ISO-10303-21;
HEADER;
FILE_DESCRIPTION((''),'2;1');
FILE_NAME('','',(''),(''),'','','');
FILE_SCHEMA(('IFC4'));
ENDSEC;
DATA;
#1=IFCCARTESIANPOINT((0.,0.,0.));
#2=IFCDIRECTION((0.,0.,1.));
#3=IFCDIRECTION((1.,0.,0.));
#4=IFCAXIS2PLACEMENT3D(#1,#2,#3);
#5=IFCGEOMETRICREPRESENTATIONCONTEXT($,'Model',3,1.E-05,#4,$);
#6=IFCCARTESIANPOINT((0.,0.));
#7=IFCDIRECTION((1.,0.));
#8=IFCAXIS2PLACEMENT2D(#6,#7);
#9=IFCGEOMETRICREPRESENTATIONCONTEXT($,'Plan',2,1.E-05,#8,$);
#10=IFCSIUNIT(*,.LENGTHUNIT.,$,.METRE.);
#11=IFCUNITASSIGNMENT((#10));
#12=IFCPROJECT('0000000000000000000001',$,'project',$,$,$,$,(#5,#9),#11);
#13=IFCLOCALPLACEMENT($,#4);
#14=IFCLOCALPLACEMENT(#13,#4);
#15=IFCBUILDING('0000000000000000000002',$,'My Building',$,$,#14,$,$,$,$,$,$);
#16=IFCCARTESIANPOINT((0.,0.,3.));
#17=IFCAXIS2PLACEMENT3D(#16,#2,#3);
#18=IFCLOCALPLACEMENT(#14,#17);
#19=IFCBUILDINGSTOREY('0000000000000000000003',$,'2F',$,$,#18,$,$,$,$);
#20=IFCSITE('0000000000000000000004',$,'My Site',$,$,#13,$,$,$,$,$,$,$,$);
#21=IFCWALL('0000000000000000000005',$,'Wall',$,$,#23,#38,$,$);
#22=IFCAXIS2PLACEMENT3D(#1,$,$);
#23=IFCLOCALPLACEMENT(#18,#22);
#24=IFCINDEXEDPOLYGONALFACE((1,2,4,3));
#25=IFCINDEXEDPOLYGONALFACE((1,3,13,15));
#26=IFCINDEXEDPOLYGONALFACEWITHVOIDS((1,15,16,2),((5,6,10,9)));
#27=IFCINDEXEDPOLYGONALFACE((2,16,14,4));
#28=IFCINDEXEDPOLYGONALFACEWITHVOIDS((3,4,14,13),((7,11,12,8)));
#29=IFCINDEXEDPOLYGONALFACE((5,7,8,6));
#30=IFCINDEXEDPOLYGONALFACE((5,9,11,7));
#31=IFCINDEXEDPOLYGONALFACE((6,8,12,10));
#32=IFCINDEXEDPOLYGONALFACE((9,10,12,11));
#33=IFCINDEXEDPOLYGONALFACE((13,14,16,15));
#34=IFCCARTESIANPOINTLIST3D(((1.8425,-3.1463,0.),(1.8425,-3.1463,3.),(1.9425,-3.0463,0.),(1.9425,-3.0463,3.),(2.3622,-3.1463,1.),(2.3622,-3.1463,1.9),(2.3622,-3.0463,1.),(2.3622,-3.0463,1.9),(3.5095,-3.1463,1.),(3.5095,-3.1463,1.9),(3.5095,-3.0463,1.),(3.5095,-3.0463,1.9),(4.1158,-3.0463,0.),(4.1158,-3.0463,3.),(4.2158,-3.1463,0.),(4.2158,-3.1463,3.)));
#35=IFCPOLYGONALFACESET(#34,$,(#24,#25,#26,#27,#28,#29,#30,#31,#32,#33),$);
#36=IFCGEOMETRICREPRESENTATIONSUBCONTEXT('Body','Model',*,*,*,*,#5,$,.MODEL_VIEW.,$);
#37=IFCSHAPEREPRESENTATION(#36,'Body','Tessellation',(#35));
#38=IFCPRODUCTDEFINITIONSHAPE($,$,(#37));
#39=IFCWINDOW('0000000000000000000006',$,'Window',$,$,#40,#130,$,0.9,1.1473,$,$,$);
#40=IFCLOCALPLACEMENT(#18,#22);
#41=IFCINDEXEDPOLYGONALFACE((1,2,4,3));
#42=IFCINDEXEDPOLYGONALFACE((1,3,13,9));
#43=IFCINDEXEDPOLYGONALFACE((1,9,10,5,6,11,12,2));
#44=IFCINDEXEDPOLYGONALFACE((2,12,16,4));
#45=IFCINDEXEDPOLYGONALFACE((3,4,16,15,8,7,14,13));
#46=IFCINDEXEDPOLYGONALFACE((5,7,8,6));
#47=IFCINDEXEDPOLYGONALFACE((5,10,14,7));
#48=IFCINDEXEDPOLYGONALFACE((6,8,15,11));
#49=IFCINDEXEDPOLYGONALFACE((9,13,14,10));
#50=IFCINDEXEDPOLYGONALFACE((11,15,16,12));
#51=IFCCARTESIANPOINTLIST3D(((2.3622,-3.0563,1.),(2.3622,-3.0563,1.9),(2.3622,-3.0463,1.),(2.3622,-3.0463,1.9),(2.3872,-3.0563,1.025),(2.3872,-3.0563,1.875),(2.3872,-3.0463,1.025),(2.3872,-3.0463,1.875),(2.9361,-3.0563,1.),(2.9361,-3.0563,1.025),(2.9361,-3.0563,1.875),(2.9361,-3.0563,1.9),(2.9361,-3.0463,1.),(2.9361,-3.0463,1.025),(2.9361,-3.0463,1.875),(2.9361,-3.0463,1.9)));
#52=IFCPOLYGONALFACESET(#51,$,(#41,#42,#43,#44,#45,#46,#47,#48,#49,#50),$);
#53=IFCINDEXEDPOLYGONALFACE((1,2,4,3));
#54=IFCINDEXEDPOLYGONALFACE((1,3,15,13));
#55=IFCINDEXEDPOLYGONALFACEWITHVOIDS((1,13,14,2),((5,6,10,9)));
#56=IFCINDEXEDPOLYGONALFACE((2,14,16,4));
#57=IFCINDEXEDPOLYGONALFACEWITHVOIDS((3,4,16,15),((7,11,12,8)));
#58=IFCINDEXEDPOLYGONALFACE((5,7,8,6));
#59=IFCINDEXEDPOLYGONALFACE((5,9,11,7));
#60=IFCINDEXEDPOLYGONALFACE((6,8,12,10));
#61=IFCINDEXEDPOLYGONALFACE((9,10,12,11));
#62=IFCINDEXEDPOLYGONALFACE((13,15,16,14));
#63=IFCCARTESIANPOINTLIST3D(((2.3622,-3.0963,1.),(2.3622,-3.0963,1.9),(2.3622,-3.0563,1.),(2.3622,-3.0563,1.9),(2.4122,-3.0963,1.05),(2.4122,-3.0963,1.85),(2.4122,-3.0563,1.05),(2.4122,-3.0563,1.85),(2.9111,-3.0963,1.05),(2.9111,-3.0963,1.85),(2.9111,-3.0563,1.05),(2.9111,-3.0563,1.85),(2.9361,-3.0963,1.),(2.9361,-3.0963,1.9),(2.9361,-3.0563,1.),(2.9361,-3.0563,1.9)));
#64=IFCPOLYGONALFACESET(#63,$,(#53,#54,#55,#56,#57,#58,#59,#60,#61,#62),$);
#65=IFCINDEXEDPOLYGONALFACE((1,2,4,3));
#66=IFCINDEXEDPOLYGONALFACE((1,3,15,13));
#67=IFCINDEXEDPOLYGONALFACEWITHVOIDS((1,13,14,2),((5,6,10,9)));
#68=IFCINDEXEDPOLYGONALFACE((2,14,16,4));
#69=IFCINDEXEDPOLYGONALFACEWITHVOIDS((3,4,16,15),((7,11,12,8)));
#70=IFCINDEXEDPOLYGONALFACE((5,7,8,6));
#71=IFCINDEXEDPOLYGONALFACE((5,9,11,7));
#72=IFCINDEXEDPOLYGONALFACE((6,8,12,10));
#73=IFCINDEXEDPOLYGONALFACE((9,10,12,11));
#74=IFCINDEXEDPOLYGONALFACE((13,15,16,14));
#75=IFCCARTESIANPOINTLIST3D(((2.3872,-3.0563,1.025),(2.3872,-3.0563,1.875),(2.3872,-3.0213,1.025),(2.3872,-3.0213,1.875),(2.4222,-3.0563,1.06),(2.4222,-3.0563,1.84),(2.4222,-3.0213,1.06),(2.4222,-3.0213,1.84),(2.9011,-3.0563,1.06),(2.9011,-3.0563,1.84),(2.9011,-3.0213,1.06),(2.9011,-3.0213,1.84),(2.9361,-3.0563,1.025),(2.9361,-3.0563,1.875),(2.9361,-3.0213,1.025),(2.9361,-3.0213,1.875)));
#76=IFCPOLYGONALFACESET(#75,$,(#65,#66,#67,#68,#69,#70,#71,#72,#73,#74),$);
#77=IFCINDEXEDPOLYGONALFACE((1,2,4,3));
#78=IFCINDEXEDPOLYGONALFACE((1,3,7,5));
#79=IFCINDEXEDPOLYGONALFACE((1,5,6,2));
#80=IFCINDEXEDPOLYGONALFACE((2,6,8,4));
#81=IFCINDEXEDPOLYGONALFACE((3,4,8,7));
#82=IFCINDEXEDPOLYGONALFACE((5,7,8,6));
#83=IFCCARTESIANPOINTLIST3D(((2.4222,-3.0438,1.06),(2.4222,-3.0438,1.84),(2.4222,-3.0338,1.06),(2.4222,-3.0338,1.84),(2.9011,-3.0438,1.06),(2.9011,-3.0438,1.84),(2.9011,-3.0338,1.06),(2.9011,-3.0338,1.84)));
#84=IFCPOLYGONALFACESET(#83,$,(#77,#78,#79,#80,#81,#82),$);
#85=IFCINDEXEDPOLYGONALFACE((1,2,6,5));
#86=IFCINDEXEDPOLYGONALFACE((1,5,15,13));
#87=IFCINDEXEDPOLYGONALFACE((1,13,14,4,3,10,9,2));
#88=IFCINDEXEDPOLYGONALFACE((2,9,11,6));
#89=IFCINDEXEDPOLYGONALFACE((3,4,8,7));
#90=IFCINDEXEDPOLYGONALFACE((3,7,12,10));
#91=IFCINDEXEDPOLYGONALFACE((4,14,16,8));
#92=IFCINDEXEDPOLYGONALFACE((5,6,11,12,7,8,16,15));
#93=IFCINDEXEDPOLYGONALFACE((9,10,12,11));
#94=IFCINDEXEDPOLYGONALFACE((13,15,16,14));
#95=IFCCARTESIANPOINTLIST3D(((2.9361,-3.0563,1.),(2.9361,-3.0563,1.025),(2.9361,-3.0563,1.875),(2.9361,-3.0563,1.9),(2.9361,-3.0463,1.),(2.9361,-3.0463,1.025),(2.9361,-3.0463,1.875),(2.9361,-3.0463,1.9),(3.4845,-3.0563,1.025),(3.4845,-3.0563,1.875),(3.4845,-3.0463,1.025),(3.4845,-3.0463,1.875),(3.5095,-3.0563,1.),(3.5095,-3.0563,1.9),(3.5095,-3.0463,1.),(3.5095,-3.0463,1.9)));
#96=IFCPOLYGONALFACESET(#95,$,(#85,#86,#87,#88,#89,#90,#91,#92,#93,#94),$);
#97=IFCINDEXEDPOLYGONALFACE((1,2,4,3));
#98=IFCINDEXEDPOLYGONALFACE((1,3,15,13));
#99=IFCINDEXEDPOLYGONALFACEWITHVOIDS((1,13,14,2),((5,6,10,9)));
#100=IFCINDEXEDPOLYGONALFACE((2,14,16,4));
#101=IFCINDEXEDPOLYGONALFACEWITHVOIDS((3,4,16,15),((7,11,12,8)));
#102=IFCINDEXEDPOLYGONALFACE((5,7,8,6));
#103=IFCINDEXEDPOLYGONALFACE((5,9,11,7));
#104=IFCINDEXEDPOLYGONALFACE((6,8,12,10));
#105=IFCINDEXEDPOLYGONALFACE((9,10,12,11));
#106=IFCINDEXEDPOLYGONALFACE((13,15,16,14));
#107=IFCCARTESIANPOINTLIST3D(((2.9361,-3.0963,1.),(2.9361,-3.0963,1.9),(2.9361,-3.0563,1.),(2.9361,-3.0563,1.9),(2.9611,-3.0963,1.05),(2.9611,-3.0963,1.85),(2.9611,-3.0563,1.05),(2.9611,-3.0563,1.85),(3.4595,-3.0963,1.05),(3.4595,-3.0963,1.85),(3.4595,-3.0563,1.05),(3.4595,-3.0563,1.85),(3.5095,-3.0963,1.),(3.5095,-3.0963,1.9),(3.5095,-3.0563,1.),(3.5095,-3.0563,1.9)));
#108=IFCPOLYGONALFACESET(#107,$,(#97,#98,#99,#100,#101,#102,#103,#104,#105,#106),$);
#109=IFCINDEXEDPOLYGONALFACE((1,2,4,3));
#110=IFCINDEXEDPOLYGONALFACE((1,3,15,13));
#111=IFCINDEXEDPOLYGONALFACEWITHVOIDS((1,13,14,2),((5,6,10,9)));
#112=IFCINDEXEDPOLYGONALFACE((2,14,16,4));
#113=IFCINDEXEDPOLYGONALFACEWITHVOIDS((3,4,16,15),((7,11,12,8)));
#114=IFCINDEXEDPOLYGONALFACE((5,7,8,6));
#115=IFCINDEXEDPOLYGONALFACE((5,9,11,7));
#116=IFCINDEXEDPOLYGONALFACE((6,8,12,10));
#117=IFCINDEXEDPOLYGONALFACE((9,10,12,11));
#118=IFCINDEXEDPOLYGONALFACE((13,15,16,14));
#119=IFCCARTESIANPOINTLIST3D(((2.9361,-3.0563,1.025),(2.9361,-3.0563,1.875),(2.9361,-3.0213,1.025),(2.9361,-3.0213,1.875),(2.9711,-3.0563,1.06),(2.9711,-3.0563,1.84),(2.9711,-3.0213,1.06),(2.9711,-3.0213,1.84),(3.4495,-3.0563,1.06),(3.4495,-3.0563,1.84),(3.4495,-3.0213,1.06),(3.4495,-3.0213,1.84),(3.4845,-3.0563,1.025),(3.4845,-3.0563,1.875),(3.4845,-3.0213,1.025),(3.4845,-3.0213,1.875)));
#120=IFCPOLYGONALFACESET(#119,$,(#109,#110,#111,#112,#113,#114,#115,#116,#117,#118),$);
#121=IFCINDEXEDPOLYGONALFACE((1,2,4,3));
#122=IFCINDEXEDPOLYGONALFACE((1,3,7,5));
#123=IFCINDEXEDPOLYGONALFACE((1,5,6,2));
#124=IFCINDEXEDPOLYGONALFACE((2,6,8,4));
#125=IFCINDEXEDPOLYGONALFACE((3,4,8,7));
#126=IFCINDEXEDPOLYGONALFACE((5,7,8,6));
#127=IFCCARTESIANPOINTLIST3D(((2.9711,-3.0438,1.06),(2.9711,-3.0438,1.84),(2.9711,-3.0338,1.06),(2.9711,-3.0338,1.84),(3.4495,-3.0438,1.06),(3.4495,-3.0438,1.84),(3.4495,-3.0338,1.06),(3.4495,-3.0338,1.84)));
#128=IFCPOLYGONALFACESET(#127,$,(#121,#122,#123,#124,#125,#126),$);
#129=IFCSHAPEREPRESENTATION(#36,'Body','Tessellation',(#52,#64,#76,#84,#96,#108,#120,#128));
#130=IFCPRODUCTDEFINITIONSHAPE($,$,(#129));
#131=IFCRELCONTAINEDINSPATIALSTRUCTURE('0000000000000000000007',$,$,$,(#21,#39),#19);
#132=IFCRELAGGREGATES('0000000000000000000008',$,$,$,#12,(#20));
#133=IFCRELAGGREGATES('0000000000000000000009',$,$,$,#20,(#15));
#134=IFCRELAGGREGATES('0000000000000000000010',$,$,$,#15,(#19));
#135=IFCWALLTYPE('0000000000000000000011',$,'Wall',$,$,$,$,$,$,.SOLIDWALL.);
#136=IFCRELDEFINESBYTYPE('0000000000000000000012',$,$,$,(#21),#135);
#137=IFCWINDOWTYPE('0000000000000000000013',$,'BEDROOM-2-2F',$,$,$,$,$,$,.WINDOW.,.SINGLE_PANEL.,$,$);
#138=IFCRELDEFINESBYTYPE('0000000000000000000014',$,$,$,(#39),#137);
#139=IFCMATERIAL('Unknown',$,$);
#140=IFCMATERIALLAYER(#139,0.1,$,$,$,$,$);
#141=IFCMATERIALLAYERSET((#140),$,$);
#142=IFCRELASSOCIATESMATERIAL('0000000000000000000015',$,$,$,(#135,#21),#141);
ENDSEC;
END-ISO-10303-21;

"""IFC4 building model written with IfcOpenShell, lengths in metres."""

from ifc_helpers import new_model, entity, si_unit, frame, origin_with_axes, origin_2d_with_axis, place, context, subcontext, project, spatial, line, indexed_curve, outline, extrude, shape, source, transform, mapped, material, layer, layer_set, layer_usage, type_object, type_shapes, element, fill, save


model = new_model("IFC4")

# Units and contexts
model_context = context("Model", 3, precision=1e-05, world=origin_with_axes())
plan_context = context("Plan", 2, precision=1e-05, world=origin_2d_with_axis())
body_context_1 = subcontext(model_context, "Body", "Model", "MODEL_VIEW")
body_context_2 = subcontext(plan_context, "Body", "Plan", "PLAN_VIEW")
ifc_project = project(units=[si_unit("LENGTHUNIT", "METRE")], contexts=[model_context, plan_context])

# Site, building, storey
site_placement = place(None, origin_with_axes())
site = spatial("IfcSite", under=ifc_project, at=site_placement, Name="My Site")
building_placement = place(site_placement, origin_with_axes())
building = spatial("IfcBuilding", under=site, at=building_placement, Name="My Building")
storey_placement = place(building_placement, frame((0.0, 0.0, 3.0), z_axis=(0.0, 0.0, 1.0), x_axis=(1.0, 0.0, 0.0)))
storey = spatial("IfcBuildingStorey", under=building, at=storey_placement, Name="2F")

# Shared definitions
ifc_material_1 = material(Name="Unknown")

# Shared definitions
ifc_layer_1 = layer(ifc_material_1, 0.1)
ifc_layer_set_1 = layer_set([ifc_layer_1])
wall_type = type_object("IfcWallType", Name="Wall", PredefinedType="SOLIDWALL", material=ifc_layer_set_1)

# Wall, opening, window
ifc_layer_usage_1 = layer_usage(ifc_layer_set_1, "AXIS2", "POSITIVE", 0.0)
wall_1_placement = place(storey_placement, frame((1.8425, -3.1463, 0.0), z_axis=(0.0, 0.0, 1.0), x_axis=(1.0, 0.0, 0.0)))
wall_1 = element("IfcWall", 1, at=wall_1_placement, inside=storey, type_object=wall_type, material=ifc_layer_usage_1, Name="Wall", context=body_context_1, shape_type="SweptSolid", body=[
    extrude(outline(indexed_curve([(0.0, 0.0), (0.1, 0.1), (2.2734, 0.1), (2.3734, 0.0)], segments=[line(1, 2, 3, 4, 1)])), origin_with_axes(), (0.0, 0.0, 1.0), 3.0),
])
shared_shape_1 = source(origin_with_axes(), body_context_1, "Body", "SweptSolid", [
    extrude(outline(indexed_curve([(0.0, 0.0), (1.1473, 0.0), (1.1473, 0.9), (0.0, 0.9)], segments=[line(1, 2, 3, 4, 1)])), frame((0.0, -0.6, 0.0), z_axis=(0.0, -1.0, 0.0), x_axis=(1.0, 0.0, 0.0)), (0.0, 0.0, -1.0), 1.2),
])
opening_1_placement = place(wall_1_placement, frame((0.5197, 0.0, 1.0), z_axis=(0.0, 0.0, 1.0), x_axis=(1.0, 0.0, 0.0)))
opening_1 = element("IfcOpeningElement", 2, at=opening_1_placement, cuts=wall_1, PredefinedType="OPENING", context=body_context_1, shape_type="MappedRepresentation", body=[
    mapped(shared_shape_1, transform((0.0, 0.0, 0.0), x_axis=(1.0, 0.0, 0.0), y_axis=(0.0, 1.0, 0.0), z_axis=(0.0, 0.0, 1.0), scale=1.0)),
])
window_type_1 = type_object("IfcWindowType", Name="BEDROOM-2-2F", PartitioningType="SINGLE_PANEL", PredefinedType="WINDOW")
shared_shape_2 = source(origin_with_axes(), body_context_1, "Body", "SweptSolid", [
    extrude(outline(indexed_curve([(0.5739, 0.0), (0.0, 0.0), (0.0, 0.9), (0.5739, 0.9), (0.5739, 0.875), (0.025, 0.875), (0.025, 0.025), (0.5739, 0.025)], segments=[line(1, 2, 3, 4, 5, 6, 7, 8, 1)])), frame((0.0, 0.09, 0.0), z_axis=(0.0, -1.0, 0.0), x_axis=(1.0, 0.0, 0.0)), (0.0, 0.0, -1.0), 0.01),
    extrude(outline(indexed_curve([(0.0, 0.0), (0.5739, 0.0), (0.5739, 0.9), (0.0, 0.9)], segments=[line(1, 2, 3, 4, 1)]), holes=[indexed_curve([(0.05, 0.05), (0.5489, 0.05), (0.5489, 0.85), (0.05, 0.85)], segments=[line(1, 2, 3, 4, 1)])]), frame((0.0, 0.05, 0.0), z_axis=(0.0, -1.0, 0.0), x_axis=(1.0, 0.0, 0.0)), (0.0, 0.0, -1.0), 0.04),
    extrude(outline(indexed_curve([(0.0, 0.0), (0.5489, 0.0), (0.5489, 0.85), (0.0, 0.85)], segments=[line(1, 2, 3, 4, 1)]), holes=[indexed_curve([(0.035, 0.035), (0.5139, 0.035), (0.5139, 0.815), (0.035, 0.815)], segments=[line(1, 2, 3, 4, 1)])]), frame((0.025, 0.09, 0.025), z_axis=(0.0, -1.0, 0.0), x_axis=(1.0, 0.0, 0.0)), (0.0, 0.0, -1.0), 0.035),
    extrude(outline(indexed_curve([(0.035, 0.035), (0.5139, 0.035), (0.5139, 0.815), (0.035, 0.815)], segments=[line(1, 2, 3, 4, 1)])), frame((0.025, 0.1025, 0.025), z_axis=(0.0, -1.0, 0.0), x_axis=(1.0, 0.0, 0.0)), (0.0, 0.0, -1.0), 0.01),
    extrude(outline(indexed_curve([(0.0, 0.9), (0.5733, 0.9), (0.5733, 0.0), (0.0, 0.0), (0.0, 0.025), (0.5483, 0.025), (0.5483, 0.875), (0.0, 0.875)], segments=[line(1, 2, 3, 4, 5, 6, 7, 8, 1)])), frame((0.5739, 0.09, 0.0), z_axis=(0.0, -1.0, 0.0), x_axis=(1.0, 0.0, 0.0)), (0.0, 0.0, -1.0), 0.01),
    extrude(outline(indexed_curve([(0.0, 0.0), (0.5733, 0.0), (0.5733, 0.9), (0.0, 0.9)], segments=[line(1, 2, 3, 4, 1)]), holes=[indexed_curve([(0.025, 0.05), (0.5233, 0.05), (0.5233, 0.85), (0.025, 0.85)], segments=[line(1, 2, 3, 4, 1)])]), frame((0.5739, 0.05, 0.0), z_axis=(0.0, -1.0, 0.0), x_axis=(1.0, 0.0, 0.0)), (0.0, 0.0, -1.0), 0.04),
    extrude(outline(indexed_curve([(0.0, 0.0), (0.5483, 0.0), (0.5483, 0.85), (0.0, 0.85)], segments=[line(1, 2, 3, 4, 1)]), holes=[indexed_curve([(0.035, 0.035), (0.5133, 0.035), (0.5133, 0.815), (0.035, 0.815)], segments=[line(1, 2, 3, 4, 1)])]), frame((0.5739, 0.09, 0.025), z_axis=(0.0, -1.0, 0.0), x_axis=(1.0, 0.0, 0.0)), (0.0, 0.0, -1.0), 0.035),
    extrude(outline(indexed_curve([(0.035, 0.035), (0.5133, 0.035), (0.5133, 0.815), (0.035, 0.815)], segments=[line(1, 2, 3, 4, 1)])), frame((0.5739, 0.1025, 0.025), z_axis=(0.0, -1.0, 0.0), x_axis=(1.0, 0.0, 0.0)), (0.0, 0.0, -1.0), 0.01),
])
shared_shape_3 = source(origin_with_axes(), body_context_2, "Body", "Curve2D", [
    entity("IfcIndexedPolyCurve", entity("IfcCartesianPointList2D", [[0.05, 0.05], [0.5489, 0.05]])),
    entity("IfcIndexedPolyCurve", entity("IfcCartesianPointList2D", [[0.0, 0.1], [0.025, 0.1], [0.025, 0.09], [0.05, 0.09], [0.05, 0.05], [0.0, 0.05]]), [entity("IfcLineIndex", [1, 2, 3, 4, 5, 6, 1])]),
    entity("IfcIndexedPolyCurve", entity("IfcCartesianPointList2D", [[0.5739, 0.1], [0.5739, 0.1], [0.5739, 0.09], [0.5489, 0.09], [0.5489, 0.05], [0.5739, 0.05]])),
    entity("IfcIndexedPolyCurve", entity("IfcCartesianPointList2D", [[0.025, 0.09], [0.06, 0.09], [0.06, 0.125], [0.025, 0.125]]), [entity("IfcLineIndex", [1, 2, 3, 4, 1])]),
    entity("IfcIndexedPolyCurve", entity("IfcCartesianPointList2D", [[0.5739, 0.09], [0.5389, 0.09], [0.5389, 0.125], [0.5739, 0.125]]), [entity("IfcLineIndex", [1, 2, 3, 4, 1])]),
    entity("IfcIndexedPolyCurve", entity("IfcCartesianPointList2D", [[0.06, 0.09], [0.5389, 0.09]])),
    entity("IfcIndexedPolyCurve", entity("IfcCartesianPointList2D", [[0.06, 0.125], [0.5389, 0.125]])),
    entity("IfcIndexedPolyCurve", entity("IfcCartesianPointList2D", [[0.06, 0.1075], [0.5389, 0.1075]])),
    entity("IfcIndexedPolyCurve", entity("IfcCartesianPointList2D", [[0.5989, 0.05], [1.0973, 0.05]])),
    entity("IfcIndexedPolyCurve", entity("IfcCartesianPointList2D", [[0.5739, 0.1], [0.5739, 0.1], [0.5739, 0.09], [0.5989, 0.09], [0.5989, 0.05], [0.5739, 0.05]])),
    entity("IfcIndexedPolyCurve", entity("IfcCartesianPointList2D", [[1.1473, 0.1], [1.1223, 0.1], [1.1223, 0.09], [1.0973, 0.09], [1.0973, 0.05], [1.1473, 0.05]]), [entity("IfcLineIndex", [1, 2, 3, 4, 5, 6, 1])]),
    entity("IfcIndexedPolyCurve", entity("IfcCartesianPointList2D", [[0.5739, 0.09], [0.6089, 0.09], [0.6089, 0.125], [0.5739, 0.125]]), [entity("IfcLineIndex", [1, 2, 3, 4, 1])]),
    entity("IfcIndexedPolyCurve", entity("IfcCartesianPointList2D", [[1.1223, 0.09], [1.0873, 0.09], [1.0873, 0.125], [1.1223, 0.125]]), [entity("IfcLineIndex", [1, 2, 3, 4, 1])]),
    entity("IfcIndexedPolyCurve", entity("IfcCartesianPointList2D", [[0.6089, 0.09], [1.0873, 0.09]])),
    entity("IfcIndexedPolyCurve", entity("IfcCartesianPointList2D", [[0.6089, 0.125], [1.0873, 0.125]])),
    entity("IfcIndexedPolyCurve", entity("IfcCartesianPointList2D", [[0.6089, 0.1075], [1.0873, 0.1075]])),
])
type_shapes(window_type_1, [shared_shape_2, shared_shape_3])
window_1_placement = place(opening_1_placement, origin_with_axes())
window_1 = element("IfcWindow", 3, at=window_1_placement, inside=storey, type_object=window_type_1, Name="Window", OverallHeight=0.9, OverallWidth=1.1473, shapes=[
    shape(body_context_1, "Body", "MappedRepresentation", [mapped(shared_shape_2, transform((0.0, 0.0, 0.0), x_axis=(1.0, 0.0, 0.0), y_axis=(0.0, 1.0, 0.0), z_axis=(0.0, 0.0, 1.0), scale=1.0))]),
    shape(body_context_2, "Body", "MappedRepresentation", [mapped(shared_shape_3, transform((0.0, 0.0, 0.0), x_axis=(1.0, 0.0, 0.0), y_axis=(0.0, 1.0, 0.0), z_axis=(0.0, 0.0, 1.0), scale=1.0))]),
])
fill(opening_1, window_1)

save(model, "model.ifc")
